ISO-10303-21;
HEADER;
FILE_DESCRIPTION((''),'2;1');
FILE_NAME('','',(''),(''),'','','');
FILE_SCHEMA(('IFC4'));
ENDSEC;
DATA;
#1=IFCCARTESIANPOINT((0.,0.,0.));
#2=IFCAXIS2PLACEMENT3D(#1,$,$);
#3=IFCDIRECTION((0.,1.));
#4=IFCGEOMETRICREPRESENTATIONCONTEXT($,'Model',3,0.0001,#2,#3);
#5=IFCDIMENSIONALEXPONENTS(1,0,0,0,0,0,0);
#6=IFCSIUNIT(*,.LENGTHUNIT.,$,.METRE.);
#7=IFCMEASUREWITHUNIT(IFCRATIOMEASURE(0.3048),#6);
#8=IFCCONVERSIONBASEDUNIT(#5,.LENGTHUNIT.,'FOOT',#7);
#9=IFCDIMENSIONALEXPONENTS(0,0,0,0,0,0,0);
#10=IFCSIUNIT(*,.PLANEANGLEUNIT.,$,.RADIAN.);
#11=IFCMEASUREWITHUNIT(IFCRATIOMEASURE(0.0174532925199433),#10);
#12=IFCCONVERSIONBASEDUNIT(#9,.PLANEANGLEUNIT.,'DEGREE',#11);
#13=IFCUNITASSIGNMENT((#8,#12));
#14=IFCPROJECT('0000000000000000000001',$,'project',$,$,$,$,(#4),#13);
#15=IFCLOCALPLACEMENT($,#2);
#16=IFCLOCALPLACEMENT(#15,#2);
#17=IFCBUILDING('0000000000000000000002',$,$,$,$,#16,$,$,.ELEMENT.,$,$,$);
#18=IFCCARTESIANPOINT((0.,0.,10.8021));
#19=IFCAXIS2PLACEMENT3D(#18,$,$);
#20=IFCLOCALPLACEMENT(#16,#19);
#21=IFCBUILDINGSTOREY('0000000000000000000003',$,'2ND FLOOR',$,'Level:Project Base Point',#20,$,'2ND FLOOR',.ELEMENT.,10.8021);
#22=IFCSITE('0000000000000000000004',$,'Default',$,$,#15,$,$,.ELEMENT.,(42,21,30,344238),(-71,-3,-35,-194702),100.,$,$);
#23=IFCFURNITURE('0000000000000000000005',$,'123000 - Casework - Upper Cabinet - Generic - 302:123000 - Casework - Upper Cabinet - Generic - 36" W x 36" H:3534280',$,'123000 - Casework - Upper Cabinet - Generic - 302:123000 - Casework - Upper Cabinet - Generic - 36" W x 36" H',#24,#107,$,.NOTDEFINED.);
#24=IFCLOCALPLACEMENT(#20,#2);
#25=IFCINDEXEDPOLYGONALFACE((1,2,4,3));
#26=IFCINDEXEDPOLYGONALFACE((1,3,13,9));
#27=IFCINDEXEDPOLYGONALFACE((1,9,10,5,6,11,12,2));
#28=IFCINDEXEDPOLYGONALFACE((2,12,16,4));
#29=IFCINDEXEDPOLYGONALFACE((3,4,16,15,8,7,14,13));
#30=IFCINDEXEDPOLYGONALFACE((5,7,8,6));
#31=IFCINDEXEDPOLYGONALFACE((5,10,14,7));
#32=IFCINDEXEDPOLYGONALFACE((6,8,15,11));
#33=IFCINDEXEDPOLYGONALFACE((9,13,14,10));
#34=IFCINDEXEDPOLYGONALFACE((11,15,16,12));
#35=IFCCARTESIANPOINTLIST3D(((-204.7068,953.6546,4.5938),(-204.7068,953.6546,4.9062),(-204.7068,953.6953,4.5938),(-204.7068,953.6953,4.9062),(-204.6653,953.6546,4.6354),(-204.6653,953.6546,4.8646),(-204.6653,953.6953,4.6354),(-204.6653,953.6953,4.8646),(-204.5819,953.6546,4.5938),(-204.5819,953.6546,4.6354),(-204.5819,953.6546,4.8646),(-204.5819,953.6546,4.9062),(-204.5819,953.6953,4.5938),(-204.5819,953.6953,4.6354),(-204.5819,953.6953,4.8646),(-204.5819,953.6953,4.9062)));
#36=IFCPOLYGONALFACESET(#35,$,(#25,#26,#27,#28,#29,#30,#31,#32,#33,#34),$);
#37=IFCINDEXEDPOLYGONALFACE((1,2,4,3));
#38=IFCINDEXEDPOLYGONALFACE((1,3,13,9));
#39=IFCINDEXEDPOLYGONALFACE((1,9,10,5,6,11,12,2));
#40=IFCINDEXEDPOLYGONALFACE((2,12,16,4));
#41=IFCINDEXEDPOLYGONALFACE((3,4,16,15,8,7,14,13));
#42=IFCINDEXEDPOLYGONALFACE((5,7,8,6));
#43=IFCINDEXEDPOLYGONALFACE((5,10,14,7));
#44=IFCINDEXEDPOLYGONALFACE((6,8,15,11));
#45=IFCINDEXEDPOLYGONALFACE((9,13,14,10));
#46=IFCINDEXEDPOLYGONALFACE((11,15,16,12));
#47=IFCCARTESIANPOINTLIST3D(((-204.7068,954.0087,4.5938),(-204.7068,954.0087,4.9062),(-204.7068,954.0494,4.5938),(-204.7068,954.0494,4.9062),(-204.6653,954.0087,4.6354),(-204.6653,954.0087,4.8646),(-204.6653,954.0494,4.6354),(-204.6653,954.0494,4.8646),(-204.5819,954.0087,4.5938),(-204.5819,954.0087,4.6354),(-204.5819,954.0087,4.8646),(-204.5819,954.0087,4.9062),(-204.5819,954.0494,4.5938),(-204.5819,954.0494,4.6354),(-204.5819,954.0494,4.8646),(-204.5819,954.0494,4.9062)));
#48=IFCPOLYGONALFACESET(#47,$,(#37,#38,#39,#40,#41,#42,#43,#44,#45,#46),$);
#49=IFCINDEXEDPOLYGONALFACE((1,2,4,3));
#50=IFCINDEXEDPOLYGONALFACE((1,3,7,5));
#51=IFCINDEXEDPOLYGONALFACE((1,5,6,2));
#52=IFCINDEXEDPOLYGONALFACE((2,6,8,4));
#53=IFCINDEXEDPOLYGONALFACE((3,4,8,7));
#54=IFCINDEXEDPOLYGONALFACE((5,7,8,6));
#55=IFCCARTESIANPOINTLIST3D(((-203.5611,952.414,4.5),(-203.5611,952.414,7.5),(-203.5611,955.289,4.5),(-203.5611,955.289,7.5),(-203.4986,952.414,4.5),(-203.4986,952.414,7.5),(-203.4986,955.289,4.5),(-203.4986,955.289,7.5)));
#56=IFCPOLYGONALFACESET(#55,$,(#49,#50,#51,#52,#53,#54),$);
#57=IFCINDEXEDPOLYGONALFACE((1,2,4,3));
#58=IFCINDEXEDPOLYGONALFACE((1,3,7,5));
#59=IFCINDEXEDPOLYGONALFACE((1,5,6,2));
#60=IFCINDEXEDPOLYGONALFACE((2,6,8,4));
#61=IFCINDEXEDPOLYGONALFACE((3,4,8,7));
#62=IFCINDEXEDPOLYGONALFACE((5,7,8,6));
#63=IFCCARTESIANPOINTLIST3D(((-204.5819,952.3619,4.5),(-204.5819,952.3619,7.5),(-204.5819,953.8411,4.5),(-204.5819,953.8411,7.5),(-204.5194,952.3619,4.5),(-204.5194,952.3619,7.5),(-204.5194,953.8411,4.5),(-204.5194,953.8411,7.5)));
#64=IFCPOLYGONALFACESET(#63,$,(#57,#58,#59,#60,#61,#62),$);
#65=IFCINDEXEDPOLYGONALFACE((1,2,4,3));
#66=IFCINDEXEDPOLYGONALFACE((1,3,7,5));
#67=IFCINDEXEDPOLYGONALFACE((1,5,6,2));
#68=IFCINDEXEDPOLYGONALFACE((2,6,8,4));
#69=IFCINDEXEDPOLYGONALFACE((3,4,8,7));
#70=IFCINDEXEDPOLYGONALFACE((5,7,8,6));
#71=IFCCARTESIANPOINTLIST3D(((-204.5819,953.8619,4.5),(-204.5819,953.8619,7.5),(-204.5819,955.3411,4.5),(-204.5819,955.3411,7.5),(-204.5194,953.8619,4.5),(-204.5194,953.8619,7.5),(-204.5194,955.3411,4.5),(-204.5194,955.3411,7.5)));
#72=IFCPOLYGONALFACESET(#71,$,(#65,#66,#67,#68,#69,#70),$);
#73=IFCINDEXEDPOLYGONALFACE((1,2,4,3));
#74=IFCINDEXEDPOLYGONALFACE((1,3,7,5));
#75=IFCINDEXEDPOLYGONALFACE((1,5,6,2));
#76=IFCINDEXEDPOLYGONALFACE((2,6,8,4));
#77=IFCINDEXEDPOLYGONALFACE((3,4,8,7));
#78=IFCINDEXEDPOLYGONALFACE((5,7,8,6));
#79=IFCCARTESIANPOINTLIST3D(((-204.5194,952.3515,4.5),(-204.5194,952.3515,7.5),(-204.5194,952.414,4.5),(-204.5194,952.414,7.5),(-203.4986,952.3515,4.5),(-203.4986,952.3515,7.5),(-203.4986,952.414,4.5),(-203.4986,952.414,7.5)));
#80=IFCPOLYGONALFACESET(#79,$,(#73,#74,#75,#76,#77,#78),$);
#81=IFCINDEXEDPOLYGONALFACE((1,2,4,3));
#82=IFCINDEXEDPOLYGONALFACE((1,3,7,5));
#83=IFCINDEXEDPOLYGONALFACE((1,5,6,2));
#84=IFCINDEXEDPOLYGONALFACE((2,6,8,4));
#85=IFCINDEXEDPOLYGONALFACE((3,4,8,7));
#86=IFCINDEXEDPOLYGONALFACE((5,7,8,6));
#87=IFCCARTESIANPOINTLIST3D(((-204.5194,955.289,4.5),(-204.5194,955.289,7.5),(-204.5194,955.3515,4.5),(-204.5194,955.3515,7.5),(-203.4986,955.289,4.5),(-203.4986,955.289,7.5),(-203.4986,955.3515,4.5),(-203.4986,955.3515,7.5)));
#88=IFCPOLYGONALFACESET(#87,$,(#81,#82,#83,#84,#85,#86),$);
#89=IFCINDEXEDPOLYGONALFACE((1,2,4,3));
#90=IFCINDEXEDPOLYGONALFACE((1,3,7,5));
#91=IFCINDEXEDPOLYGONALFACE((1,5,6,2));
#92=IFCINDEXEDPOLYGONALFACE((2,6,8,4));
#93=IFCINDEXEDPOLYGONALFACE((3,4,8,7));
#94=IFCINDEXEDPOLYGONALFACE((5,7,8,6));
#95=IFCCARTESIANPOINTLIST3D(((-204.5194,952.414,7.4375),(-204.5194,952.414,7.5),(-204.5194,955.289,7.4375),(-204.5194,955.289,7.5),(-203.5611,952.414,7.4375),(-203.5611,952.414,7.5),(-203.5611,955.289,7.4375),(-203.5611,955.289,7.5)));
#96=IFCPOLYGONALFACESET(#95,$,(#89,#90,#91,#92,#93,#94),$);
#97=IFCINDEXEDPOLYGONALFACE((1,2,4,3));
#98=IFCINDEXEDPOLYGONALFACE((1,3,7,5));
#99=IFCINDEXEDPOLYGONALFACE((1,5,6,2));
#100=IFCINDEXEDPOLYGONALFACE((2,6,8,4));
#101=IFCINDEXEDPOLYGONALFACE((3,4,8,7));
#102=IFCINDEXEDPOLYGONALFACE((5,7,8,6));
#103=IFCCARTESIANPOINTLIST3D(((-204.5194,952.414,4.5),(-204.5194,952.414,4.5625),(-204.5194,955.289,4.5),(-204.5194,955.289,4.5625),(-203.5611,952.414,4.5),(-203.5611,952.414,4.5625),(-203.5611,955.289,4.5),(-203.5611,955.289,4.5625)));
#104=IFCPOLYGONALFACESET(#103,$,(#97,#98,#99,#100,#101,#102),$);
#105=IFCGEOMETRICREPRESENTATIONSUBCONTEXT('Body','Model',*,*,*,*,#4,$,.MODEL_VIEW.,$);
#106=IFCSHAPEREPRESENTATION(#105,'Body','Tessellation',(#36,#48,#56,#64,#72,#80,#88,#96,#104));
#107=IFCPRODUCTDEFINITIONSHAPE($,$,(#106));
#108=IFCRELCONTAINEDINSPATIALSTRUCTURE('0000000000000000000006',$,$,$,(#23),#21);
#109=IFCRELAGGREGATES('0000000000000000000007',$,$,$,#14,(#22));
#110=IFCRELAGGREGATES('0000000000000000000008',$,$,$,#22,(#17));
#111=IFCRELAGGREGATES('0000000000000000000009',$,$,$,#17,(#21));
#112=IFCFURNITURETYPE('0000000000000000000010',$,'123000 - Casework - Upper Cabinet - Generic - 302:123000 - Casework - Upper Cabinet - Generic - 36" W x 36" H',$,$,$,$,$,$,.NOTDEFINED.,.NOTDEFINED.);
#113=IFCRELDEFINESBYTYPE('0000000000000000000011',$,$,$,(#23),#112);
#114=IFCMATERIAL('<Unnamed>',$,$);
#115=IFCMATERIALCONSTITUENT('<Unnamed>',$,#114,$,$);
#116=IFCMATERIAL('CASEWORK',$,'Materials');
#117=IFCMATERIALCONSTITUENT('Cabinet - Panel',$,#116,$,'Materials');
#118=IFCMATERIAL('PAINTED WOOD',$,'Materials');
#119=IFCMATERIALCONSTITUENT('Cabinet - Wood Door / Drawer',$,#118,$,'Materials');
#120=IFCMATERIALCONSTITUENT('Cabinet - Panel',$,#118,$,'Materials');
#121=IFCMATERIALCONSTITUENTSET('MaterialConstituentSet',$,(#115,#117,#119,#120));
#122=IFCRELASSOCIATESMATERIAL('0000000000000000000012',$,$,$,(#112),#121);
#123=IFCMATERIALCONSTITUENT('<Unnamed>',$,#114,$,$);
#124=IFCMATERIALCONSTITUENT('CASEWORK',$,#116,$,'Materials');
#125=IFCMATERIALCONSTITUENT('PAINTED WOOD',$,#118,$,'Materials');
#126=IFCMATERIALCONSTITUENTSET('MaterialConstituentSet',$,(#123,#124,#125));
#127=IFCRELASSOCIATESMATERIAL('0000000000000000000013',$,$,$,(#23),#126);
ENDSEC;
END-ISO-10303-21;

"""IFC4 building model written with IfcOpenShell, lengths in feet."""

from ifc_helpers import new_model, entity, si_unit, converted_unit, direction, frame, frame_2d, origin, origin_2d_with_axis, place, context, subcontext, project, spatial, polyline, rectangle, outline, extrude, source, transform, mapped, material, constituent, constituent_set, type_object, type_shapes, element, save


model = new_model("IFC4")

# Units and contexts
model_context = context("Model", 3, precision=0.0001, world=origin(), true_north=direction((0.0, 1.0)))
body_context = subcontext(model_context, "Body", "Model", "MODEL_VIEW")
ifc_project = project(units=[converted_unit("LENGTHUNIT", "FOOT", entity("IfcRatioMeasure", 0.3048), si_unit("LENGTHUNIT", "METRE"), dimensions=[1, 0, 0, 0, 0, 0, 0]), converted_unit("PLANEANGLEUNIT", "DEGREE", entity("IfcRatioMeasure", 0.0174532925199433), si_unit("PLANEANGLEUNIT", "RADIAN"), dimensions=[0, 0, 0, 0, 0, 0, 0])], contexts=[model_context])

# Site, building, storey
site_placement = place(None, origin())
site = spatial("IfcSite", under=ifc_project, at=site_placement, Name="Default", CompositionType="ELEMENT", RefLatitude=(42, 21, 30, 344238), RefLongitude=(-71, -3, -35, -194702), RefElevation=100.0)
building_placement = place(site_placement, origin())
building = spatial("IfcBuilding", under=site, at=building_placement, CompositionType="ELEMENT")
storey_placement = place(building_placement, frame((0.0, 0.0, 10.8021)))
storey = spatial("IfcBuildingStorey", under=building, at=storey_placement, Name="2ND FLOOR", ObjectType="Level:Project Base Point", LongName="2ND FLOOR", CompositionType="ELEMENT", Elevation=10.8021)

# Furniture
ifc_material_1 = material(Name="CASEWORK", Category="Materials")
ifc_material_2 = material(Name="<Unnamed>")
ifc_material_3 = material(Name="PAINTED WOOD", Category="Materials")
ifc_constituent_1 = constituent(ifc_material_2, Name="<Unnamed>")
ifc_constituent_2 = constituent(ifc_material_1, Name="CASEWORK", Category="Materials")
ifc_constituent_3 = constituent(ifc_material_3, Name="PAINTED WOOD", Category="Materials")
ifc_constituent_set_1 = constituent_set(constituents=[ifc_constituent_1, ifc_constituent_2, ifc_constituent_3], Name="MaterialConstituentSet")
ifc_constituent_4 = constituent(ifc_material_2, Name="<Unnamed>")
ifc_constituent_5 = constituent(ifc_material_1, Name="Cabinet - Panel", Category="Materials")
ifc_constituent_6 = constituent(ifc_material_3, Name="Cabinet - Wood Door / Drawer", Category="Materials")
ifc_constituent_7 = constituent(ifc_material_3, Name="Cabinet - Panel", Category="Materials")
ifc_constituent_set_2 = constituent_set(constituents=[ifc_constituent_4, ifc_constituent_5, ifc_constituent_6, ifc_constituent_7], Name="MaterialConstituentSet")
furniture_type_1 = type_object("IfcFurnitureType", Name="123000 - Casework - Upper Cabinet - Generic - 302:123000 - Casework - Upper Cabinet - Generic - 36\" W x 36\" H", AssemblyPlace="NOTDEFINED", PredefinedType="NOTDEFINED", material=ifc_constituent_set_2)
shared_shape_1 = source(origin(), body_context, "Body", "SweptSolid", [
    extrude(outline(polyline([(-0.0521, -0.1146), (-0.0521, -0.1562), (0.0729, -0.1562), (0.0729, 0.1562), (-0.0521, 0.1562), (-0.0521, 0.1146), (0.0313, 0.1146), (0.0313, -0.1146), (-0.0521, -0.1146)])), frame((1.303, 1.1354, 0.25), z_axis=(-1.0, 0.0, 0.0), x_axis=(0.0, 1.0, 0.0)), (0.0, 0.0, -1.0), 0.0407),
    extrude(outline(polyline([(-0.0521, -0.1146), (-0.0521, -0.1562), (0.0729, -0.1562), (0.0729, 0.1562), (-0.0521, 0.1562), (-0.0521, 0.1146), (0.0313, 0.1146), (0.0313, -0.1146), (-0.0521, -0.1146)])), frame((1.6572, 1.1354, 0.25), z_axis=(-1.0, 0.0, 0.0), x_axis=(0.0, 1.0, 0.0)), (0.0, 0.0, -1.0), 0.0407),
    extrude(rectangle(XDim=2.875, YDim=0.0625, at=frame_2d((0.0, 0.0), x_axis=(1.0, 0.0))), frame((1.5, 0.0313, 0.0), z_axis=(0.0, 0.0, 1.0), x_axis=(-1.0, 0.0, 0.0)), (0.0, 0.0, 1.0), 3.0),
    extrude(rectangle(XDim=1.4792, YDim=0.0625, at=origin_2d_with_axis()), frame((0.75, 1.0521, 0.0)), (0.0, 0.0, 1.0), 3.0),
    extrude(rectangle(XDim=1.4792, YDim=0.0625, at=origin_2d_with_axis()), frame((2.25, 1.0521, 0.0)), (0.0, 0.0, 1.0), 3.0),
    extrude(rectangle(XDim=1.0208, YDim=0.0625, at=origin_2d_with_axis()), frame((0.0312, 0.5104, 0.0), z_axis=(0.0, 0.0, 1.0), x_axis=(0.0, 1.0, 0.0)), (0.0, 0.0, 1.0), 3.0),
    extrude(rectangle(XDim=1.0208, YDim=0.0625, at=frame_2d((0.0, 0.0), x_axis=(1.0, 0.0))), frame((2.9688, 0.5104, 0.0), z_axis=(0.0, 0.0, 1.0), x_axis=(0.0, 1.0, 0.0)), (0.0, 0.0, 1.0), 3.0),
    extrude(rectangle(XDim=0.9583, YDim=2.875, at=frame_2d((0.0, 0.0), x_axis=(1.0, 0.0))), frame((1.5, 0.5417, 2.9375), z_axis=(0.0, 0.0, 1.0), x_axis=(0.0, 1.0, 0.0)), (0.0, 0.0, 1.0), 0.0625),
    extrude(rectangle(XDim=0.9583, YDim=2.875, at=frame_2d((0.0, 0.0), x_axis=(1.0, 0.0))), frame((1.5, 0.5417, 0.0), z_axis=(0.0, 0.0, 1.0), x_axis=(0.0, 1.0, 0.0)), (0.0, 0.0, 1.0), 0.0625),
])
type_shapes(furniture_type_1, [shared_shape_1])
furniture_1_placement = place(storey_placement, frame((-203.4986, 952.3515, 4.5), z_axis=(0.0, 0.0, 1.0), x_axis=(0.0, 1.0, 0.0)))
element("IfcFurniture", 1, at=furniture_1_placement, inside=storey, type_object=furniture_type_1, material=ifc_constituent_set_1, Name="123000 - Casework - Upper Cabinet - Generic - 302:123000 - Casework - Upper Cabinet - Generic - 36\" W x 36\" H:3534280", ObjectType="123000 - Casework - Upper Cabinet - Generic - 302:123000 - Casework - Upper Cabinet - Generic - 36\" W x 36\" H", PredefinedType="NOTDEFINED", context=body_context, shape_type="MappedRepresentation", body=[
    mapped(shared_shape_1, transform((0.0, 0.0, 0.0), scale=1.0)),
])

save(model, "model.ifc")
